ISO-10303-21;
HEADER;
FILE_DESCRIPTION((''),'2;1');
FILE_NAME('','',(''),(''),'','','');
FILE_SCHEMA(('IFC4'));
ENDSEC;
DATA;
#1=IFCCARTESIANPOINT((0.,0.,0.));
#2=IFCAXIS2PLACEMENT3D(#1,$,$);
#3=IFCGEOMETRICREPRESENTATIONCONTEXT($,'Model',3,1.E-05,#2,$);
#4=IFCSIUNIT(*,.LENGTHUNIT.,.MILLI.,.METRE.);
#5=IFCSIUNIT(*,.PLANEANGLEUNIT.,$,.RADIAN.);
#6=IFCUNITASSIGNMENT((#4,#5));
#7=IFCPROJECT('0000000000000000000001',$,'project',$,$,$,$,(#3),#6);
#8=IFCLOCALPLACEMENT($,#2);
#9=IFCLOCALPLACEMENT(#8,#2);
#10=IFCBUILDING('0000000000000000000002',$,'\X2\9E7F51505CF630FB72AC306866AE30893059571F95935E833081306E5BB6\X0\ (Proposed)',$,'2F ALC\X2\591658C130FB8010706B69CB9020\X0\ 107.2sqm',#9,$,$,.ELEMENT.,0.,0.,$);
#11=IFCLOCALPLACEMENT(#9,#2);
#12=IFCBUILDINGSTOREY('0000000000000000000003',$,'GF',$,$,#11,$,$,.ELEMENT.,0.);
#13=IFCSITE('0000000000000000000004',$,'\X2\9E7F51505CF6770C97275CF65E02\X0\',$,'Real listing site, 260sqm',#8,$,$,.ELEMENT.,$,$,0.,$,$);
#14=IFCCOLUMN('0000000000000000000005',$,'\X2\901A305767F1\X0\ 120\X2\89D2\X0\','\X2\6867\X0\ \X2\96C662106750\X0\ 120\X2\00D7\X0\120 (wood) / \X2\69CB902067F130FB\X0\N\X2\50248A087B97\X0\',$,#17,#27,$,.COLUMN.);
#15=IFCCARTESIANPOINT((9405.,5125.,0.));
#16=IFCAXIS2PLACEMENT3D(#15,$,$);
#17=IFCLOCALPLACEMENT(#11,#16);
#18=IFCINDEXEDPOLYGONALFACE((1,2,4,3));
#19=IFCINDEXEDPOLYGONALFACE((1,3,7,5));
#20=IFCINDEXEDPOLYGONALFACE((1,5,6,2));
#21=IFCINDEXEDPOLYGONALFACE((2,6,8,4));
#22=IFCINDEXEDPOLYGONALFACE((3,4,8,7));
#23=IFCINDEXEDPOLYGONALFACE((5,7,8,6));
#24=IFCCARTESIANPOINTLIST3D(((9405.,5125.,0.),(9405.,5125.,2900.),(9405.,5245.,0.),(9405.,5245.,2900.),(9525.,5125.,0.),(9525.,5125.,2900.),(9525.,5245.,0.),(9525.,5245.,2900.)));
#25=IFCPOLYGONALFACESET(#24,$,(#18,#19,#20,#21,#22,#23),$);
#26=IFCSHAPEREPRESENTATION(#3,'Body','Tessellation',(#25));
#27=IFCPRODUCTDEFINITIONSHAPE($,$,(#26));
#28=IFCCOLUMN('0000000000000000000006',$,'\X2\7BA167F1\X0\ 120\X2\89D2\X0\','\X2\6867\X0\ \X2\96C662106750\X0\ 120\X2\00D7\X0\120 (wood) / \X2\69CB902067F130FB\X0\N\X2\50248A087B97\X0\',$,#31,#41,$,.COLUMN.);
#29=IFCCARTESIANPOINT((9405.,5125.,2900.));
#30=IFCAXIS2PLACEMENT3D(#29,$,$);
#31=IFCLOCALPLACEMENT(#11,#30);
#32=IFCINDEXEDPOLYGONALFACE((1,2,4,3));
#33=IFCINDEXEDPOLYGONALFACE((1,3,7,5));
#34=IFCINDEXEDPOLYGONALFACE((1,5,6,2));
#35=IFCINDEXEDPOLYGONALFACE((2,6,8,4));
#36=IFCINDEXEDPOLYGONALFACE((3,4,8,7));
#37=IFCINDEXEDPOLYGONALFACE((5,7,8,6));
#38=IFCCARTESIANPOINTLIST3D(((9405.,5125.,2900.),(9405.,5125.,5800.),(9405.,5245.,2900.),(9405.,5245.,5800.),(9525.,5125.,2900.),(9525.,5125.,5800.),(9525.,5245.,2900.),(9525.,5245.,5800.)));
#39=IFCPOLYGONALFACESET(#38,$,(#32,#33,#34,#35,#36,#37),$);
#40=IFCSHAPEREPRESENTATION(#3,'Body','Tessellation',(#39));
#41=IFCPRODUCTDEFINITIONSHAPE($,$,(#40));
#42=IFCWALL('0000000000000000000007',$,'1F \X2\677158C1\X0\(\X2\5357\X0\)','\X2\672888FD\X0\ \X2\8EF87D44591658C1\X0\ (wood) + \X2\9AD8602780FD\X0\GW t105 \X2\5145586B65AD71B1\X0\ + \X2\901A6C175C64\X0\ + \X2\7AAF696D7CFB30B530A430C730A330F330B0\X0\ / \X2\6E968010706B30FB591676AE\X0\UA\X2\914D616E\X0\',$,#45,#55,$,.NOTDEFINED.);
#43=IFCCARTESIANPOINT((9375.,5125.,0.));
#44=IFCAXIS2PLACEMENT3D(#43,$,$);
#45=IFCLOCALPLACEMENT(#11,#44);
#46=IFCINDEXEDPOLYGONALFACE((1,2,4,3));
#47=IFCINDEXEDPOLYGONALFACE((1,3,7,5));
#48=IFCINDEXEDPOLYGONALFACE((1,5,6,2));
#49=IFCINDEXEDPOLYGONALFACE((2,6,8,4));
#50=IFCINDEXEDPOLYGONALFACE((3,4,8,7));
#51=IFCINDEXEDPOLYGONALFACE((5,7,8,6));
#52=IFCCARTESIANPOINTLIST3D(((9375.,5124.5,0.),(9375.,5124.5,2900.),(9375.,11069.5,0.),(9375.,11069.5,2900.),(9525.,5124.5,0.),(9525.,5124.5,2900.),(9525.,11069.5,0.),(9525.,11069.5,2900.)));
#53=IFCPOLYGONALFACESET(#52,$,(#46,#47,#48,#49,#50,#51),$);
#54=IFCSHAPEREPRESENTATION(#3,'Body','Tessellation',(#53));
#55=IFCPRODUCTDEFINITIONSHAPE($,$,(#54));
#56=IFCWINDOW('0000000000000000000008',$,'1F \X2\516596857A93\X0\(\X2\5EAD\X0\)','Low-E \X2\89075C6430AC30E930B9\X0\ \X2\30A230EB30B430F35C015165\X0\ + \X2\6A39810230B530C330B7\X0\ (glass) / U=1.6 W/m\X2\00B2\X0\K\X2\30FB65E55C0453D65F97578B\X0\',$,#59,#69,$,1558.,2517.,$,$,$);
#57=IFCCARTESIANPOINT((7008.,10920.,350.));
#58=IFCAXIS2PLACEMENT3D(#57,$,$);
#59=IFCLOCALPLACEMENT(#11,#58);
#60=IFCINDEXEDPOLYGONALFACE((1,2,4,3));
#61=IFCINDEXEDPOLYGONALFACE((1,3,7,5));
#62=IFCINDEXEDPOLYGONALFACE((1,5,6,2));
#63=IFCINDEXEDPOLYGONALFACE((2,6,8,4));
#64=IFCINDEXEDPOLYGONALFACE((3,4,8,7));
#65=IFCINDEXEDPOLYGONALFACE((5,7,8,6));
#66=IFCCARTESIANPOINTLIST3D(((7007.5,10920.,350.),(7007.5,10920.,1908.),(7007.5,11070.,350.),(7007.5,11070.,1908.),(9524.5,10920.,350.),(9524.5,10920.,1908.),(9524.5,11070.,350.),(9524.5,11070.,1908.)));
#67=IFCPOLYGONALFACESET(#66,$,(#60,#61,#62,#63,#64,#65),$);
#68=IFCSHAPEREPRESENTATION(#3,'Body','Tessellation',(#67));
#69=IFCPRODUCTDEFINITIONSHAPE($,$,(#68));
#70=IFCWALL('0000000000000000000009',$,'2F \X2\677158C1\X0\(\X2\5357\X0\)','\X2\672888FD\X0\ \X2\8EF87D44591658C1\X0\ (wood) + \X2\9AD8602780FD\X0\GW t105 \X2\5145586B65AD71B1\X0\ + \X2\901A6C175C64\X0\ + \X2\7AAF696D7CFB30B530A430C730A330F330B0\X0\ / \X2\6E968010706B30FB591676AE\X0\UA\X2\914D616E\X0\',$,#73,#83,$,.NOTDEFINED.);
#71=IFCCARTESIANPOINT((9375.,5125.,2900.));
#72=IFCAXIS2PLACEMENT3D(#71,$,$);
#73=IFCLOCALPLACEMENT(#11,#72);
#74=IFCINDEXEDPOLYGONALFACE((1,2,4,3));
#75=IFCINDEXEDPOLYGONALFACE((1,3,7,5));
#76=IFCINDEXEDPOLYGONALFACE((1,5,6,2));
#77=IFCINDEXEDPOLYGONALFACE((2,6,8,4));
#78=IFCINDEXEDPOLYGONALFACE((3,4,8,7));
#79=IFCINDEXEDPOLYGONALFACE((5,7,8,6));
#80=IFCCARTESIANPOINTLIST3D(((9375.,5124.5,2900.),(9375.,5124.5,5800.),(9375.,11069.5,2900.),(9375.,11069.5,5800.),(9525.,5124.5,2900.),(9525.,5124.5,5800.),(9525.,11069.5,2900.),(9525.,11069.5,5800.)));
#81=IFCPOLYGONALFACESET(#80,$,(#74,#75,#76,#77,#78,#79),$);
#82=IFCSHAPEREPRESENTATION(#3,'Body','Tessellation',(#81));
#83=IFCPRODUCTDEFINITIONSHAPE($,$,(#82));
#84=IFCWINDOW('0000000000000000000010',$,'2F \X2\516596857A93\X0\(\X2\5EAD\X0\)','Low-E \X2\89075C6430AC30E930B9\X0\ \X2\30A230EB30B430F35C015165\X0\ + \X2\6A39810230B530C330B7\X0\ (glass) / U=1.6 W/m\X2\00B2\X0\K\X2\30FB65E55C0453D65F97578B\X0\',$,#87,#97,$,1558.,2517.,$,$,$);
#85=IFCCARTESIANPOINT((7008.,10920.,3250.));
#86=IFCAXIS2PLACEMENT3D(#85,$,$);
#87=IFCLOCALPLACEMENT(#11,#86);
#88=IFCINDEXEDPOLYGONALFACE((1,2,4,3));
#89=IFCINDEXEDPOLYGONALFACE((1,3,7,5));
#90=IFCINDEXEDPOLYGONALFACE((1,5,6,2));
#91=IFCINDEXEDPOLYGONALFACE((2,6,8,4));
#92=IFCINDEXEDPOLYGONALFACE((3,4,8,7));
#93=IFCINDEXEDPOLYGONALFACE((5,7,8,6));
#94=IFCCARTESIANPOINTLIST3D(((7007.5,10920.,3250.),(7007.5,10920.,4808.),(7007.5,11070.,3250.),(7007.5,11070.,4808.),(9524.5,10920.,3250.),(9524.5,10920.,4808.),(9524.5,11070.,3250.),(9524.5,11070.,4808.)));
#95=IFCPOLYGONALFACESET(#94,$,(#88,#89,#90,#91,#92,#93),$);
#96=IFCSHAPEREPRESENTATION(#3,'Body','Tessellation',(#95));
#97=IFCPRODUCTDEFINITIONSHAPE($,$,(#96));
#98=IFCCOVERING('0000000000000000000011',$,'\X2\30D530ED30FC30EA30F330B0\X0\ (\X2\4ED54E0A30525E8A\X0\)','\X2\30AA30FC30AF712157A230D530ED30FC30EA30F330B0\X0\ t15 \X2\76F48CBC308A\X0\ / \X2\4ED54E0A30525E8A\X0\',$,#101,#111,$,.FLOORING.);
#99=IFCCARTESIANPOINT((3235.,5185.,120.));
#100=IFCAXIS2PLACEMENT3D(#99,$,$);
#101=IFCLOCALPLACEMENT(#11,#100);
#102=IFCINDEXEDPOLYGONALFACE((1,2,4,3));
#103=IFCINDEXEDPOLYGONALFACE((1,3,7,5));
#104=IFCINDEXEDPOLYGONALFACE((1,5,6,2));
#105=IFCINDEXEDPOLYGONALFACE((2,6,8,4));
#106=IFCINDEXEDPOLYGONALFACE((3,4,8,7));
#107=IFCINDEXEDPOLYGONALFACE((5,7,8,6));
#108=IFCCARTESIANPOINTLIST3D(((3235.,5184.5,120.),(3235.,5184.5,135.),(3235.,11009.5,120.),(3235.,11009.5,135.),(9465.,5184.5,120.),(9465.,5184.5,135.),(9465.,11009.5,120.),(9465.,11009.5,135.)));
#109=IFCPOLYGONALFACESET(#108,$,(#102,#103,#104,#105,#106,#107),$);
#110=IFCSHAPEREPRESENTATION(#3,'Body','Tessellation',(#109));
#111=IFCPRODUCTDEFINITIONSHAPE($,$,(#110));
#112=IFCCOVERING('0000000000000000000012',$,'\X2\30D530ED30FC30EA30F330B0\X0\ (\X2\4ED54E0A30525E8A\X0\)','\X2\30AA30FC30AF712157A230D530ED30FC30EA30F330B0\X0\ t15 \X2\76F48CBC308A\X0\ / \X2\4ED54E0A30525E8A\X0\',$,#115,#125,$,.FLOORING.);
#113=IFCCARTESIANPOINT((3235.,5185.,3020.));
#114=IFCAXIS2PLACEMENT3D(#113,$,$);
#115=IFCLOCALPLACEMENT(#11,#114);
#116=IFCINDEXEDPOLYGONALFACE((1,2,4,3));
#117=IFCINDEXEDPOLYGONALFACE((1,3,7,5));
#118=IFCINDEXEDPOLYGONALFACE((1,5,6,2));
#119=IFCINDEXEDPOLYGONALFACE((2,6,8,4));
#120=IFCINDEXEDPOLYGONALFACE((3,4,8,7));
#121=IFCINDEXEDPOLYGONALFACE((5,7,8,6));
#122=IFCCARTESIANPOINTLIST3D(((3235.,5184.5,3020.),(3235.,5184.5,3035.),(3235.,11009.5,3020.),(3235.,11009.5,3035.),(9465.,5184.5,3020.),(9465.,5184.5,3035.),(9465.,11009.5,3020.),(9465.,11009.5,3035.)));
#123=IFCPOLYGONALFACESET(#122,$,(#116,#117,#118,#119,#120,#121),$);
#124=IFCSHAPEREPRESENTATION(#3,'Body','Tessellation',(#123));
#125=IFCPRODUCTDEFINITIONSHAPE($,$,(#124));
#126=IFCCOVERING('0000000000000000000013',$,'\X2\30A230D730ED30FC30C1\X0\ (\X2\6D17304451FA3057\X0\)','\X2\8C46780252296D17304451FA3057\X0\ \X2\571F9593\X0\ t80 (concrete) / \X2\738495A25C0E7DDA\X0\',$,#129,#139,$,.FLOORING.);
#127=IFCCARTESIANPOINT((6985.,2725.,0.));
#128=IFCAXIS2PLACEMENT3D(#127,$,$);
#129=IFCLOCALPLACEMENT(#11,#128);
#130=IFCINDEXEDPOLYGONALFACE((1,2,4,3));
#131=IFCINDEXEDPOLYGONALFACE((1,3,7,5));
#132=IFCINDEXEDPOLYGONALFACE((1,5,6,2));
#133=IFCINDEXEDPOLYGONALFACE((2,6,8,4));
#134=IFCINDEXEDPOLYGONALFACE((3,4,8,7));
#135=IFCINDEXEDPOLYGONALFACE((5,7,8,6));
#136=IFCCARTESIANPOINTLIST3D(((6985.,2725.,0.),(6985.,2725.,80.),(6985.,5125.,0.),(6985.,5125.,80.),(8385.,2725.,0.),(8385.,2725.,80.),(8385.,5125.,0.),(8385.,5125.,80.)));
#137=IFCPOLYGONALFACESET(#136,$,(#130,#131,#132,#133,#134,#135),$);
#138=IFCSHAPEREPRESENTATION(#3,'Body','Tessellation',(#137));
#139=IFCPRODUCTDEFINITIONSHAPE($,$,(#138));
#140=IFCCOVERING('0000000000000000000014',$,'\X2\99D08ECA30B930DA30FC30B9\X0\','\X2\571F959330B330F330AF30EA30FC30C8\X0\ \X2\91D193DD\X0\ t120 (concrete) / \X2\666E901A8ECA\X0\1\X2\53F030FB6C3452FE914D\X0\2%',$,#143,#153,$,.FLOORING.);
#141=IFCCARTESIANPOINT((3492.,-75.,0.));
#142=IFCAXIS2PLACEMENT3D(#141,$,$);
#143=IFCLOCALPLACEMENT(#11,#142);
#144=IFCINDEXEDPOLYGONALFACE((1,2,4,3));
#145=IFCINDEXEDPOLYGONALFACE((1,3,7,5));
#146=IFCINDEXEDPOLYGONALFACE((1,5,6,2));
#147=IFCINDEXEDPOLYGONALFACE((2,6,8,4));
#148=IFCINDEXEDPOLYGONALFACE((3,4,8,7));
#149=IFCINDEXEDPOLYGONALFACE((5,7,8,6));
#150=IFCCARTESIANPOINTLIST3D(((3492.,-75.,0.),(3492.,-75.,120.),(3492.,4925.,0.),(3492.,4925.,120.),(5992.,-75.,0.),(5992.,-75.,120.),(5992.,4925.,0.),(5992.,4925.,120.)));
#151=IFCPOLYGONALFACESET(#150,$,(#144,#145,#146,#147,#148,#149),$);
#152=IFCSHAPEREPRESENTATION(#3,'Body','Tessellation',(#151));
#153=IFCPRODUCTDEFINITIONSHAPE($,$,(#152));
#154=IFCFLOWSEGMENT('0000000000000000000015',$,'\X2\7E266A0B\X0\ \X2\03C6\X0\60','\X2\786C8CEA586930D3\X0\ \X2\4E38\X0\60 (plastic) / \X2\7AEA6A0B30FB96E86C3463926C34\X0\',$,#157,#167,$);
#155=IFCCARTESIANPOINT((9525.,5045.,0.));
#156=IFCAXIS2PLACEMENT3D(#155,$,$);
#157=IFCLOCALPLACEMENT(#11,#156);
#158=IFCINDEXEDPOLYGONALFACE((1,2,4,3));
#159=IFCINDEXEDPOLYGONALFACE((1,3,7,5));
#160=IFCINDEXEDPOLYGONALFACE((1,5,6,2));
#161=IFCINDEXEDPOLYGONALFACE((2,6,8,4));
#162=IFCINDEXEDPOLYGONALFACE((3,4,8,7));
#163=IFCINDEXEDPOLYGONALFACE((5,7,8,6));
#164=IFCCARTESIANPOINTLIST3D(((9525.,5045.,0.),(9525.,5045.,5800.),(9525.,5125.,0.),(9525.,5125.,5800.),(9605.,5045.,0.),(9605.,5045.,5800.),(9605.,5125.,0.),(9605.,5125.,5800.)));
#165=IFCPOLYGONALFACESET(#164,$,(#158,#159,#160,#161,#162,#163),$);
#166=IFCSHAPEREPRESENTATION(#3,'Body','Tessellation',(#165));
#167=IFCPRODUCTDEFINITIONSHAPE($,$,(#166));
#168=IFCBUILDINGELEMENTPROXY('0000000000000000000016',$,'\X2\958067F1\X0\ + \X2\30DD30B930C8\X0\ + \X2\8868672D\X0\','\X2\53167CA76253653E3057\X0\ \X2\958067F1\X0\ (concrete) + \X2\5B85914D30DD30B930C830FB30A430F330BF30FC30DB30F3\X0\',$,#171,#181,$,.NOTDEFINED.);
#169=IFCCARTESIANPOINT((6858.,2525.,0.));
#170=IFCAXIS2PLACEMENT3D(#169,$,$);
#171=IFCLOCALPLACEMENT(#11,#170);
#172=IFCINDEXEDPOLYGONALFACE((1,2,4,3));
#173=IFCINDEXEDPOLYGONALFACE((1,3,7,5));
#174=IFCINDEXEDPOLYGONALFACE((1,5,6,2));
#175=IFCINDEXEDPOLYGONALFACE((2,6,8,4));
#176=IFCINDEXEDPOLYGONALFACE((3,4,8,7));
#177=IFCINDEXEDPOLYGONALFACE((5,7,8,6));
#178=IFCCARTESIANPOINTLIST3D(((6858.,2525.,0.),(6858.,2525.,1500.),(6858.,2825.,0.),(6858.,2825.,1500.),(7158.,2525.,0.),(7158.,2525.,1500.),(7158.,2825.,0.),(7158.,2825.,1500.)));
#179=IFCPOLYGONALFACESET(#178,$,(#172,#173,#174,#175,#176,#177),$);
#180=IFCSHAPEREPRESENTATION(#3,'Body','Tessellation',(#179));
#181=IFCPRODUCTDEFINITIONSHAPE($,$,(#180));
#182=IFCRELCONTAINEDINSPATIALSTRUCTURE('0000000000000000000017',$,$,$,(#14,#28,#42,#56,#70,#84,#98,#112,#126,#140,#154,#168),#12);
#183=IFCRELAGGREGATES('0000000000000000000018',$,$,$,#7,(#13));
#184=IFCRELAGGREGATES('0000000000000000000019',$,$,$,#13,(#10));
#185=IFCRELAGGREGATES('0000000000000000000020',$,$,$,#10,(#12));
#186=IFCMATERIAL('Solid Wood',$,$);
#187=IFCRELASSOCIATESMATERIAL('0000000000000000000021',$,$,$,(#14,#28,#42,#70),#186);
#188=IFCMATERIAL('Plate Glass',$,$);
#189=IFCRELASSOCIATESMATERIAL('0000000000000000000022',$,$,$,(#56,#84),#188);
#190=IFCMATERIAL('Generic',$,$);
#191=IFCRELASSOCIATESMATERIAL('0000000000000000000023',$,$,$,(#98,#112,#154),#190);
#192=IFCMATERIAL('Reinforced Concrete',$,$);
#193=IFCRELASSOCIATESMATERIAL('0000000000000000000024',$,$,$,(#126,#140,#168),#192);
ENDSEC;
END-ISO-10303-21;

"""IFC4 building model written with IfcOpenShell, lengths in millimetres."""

from ifc_helpers import new_model, si_unit, frame, frame_2d, origin, place, context, project, spatial, rectangle, extrude, material, element, fill, save


model = new_model("IFC4")

# Units and contexts
model_context = context("Model", 3, precision=1e-05, world=origin())
ifc_project = project(units=[si_unit("LENGTHUNIT", "METRE", prefix="MILLI"), si_unit("PLANEANGLEUNIT", "RADIAN")], contexts=[model_context])

# Site, building, storey
site_placement = place(None, origin())
site = spatial("IfcSite", under=ifc_project, at=site_placement, Name="鹿児島県霧島市", ObjectType="Real listing site, 260sqm", CompositionType="ELEMENT", RefElevation=0.0)
building_placement = place(site_placement, origin())
building = spatial("IfcBuilding", under=site, at=building_placement, Name="鹿児島・犬と暮らす土間広めの家 (Proposed)", ObjectType="2F ALC外壁・耐火構造 107.2sqm", CompositionType="ELEMENT", ElevationOfRefHeight=0.0, ElevationOfTerrain=0.0)
storey_placement = place(building_placement, origin())
storey = spatial("IfcBuildingStorey", under=building, at=storey_placement, Name="GF", CompositionType="ELEMENT", Elevation=0.0)

# Columns
ifc_material_1 = material(Name="Solid Wood")
column_1_placement = place(storey_placement, frame((9405.0, 5125.0, 0.0)))
element("IfcColumn", 1, at=column_1_placement, inside=storey, material=ifc_material_1, Name="通し柱 120角", Description="桧 集成材 120×120 (wood) / 構造柱・N値計算", PredefinedType="COLUMN", context=model_context, shape_type="SweptSolid", body=[
    extrude(rectangle(XDim=120.0, YDim=120.0, at=frame_2d((60.0, 60.0))), frame((9405.0, 5125.0, 0.0)), (0.0, 0.0, 1.0), 2900.0),
])
column_2_placement = place(storey_placement, frame((9405.0, 5125.0, 2900.0)))
element("IfcColumn", 2, at=column_2_placement, inside=storey, material=ifc_material_1, Name="管柱 120角", Description="桧 集成材 120×120 (wood) / 構造柱・N値計算", PredefinedType="COLUMN", context=model_context, shape_type="SweptSolid", body=[
    extrude(rectangle(XDim=120.0, YDim=120.0, at=frame_2d((60.0, 60.0))), frame((9405.0, 5125.0, 2900.0)), (0.0, 0.0, 1.0), 2900.0),
])

# Wall, opening, window
wall_1_placement = place(storey_placement, frame((9375.0, 5125.0, 0.0)))
wall_1 = element("IfcWall", 3, at=wall_1_placement, inside=storey, material=ifc_material_1, Name="1F 東壁(南)", Description="木製 軸組外壁 (wood) + 高性能GW t105 充填断熱 + 通気層 + 窯業系サイディング / 準耐火・外皮UA配慮", PredefinedType="NOTDEFINED", context=model_context, shape_type="SweptSolid", body=[
    extrude(rectangle(XDim=150.0, YDim=5945.0, at=frame_2d((75.0, 2972.0))), frame((9375.0, 5125.0, 0.0)), (0.0, 0.0, 1.0), 2900.0),
])
opening_1_placement = place(storey_placement, frame((7008.0, 10920.0, 350.0)))
opening_1 = element("IfcOpeningElement", 4, at=opening_1_placement, cuts=wall_1, PredefinedType="NOTDEFINED", context=model_context, shape_type="SweptSolid", body=[
    extrude(rectangle(XDim=2517.0, YDim=150.0, at=frame_2d((1258.0, 75.0))), frame((7008.0, 10920.0, 350.0)), (0.0, 0.0, 1.0), 1558.0),
])
ifc_material_2 = material(Name="Plate Glass")
window_1_placement = place(storey_placement, frame((7008.0, 10920.0, 350.0)))
window_1 = element("IfcWindow", 5, at=window_1_placement, inside=storey, material=ifc_material_2, Name="1F 入隅窓(庭)", Description="Low-E 複層ガラス アルゴン封入 + 樹脂サッシ (glass) / U=1.6 W/m²K・日射取得型", OverallHeight=1558.0, OverallWidth=2517.0, context=model_context, shape_type="SweptSolid", body=[
    extrude(rectangle(XDim=2517.0, YDim=150.0, at=frame_2d((1258.0, 75.0))), frame((7008.0, 10920.0, 350.0)), (0.0, 0.0, 1.0), 1558.0),
])
fill(opening_1, window_1)

# Wall, opening, window
wall_2_placement = place(storey_placement, frame((9375.0, 5125.0, 2900.0)))
wall_2 = element("IfcWall", 6, at=wall_2_placement, inside=storey, material=ifc_material_1, Name="2F 東壁(南)", Description="木製 軸組外壁 (wood) + 高性能GW t105 充填断熱 + 通気層 + 窯業系サイディング / 準耐火・外皮UA配慮", PredefinedType="NOTDEFINED", context=model_context, shape_type="SweptSolid", body=[
    extrude(rectangle(XDim=150.0, YDim=5945.0, at=frame_2d((75.0, 2972.0))), frame((9375.0, 5125.0, 2900.0)), (0.0, 0.0, 1.0), 2900.0),
])
opening_2_placement = place(storey_placement, frame((7008.0, 10920.0, 3250.0)))
opening_2 = element("IfcOpeningElement", 7, at=opening_2_placement, cuts=wall_2, PredefinedType="NOTDEFINED", context=model_context, shape_type="SweptSolid", body=[
    extrude(rectangle(XDim=2517.0, YDim=150.0, at=frame_2d((1258.0, 75.0))), frame((7008.0, 10920.0, 3250.0)), (0.0, 0.0, 1.0), 1558.0),
])
window_2_placement = place(storey_placement, frame((7008.0, 10920.0, 3250.0)))
window_2 = element("IfcWindow", 8, at=window_2_placement, inside=storey, material=ifc_material_2, Name="2F 入隅窓(庭)", Description="Low-E 複層ガラス アルゴン封入 + 樹脂サッシ (glass) / U=1.6 W/m²K・日射取得型", OverallHeight=1558.0, OverallWidth=2517.0, context=model_context, shape_type="SweptSolid", body=[
    extrude(rectangle(XDim=2517.0, YDim=150.0, at=frame_2d((1258.0, 75.0))), frame((7008.0, 10920.0, 3250.0)), (0.0, 0.0, 1.0), 1558.0),
])
fill(opening_2, window_2)

# Coverings
ifc_material_3 = material(Name="Generic")
covering_1_placement = place(storey_placement, frame((3235.0, 5185.0, 120.0)))
element("IfcCovering", 9, at=covering_1_placement, inside=storey, material=ifc_material_3, Name="フローリング (仕上げ床)", Description="オーク無垢フローリング t15 直貼り / 仕上げ床", PredefinedType="FLOORING", context=model_context, shape_type="SweptSolid", body=[
    extrude(rectangle(XDim=6230.0, YDim=5825.0, at=frame_2d((3115.0, 2912.0))), frame((3235.0, 5185.0, 120.0)), (0.0, 0.0, 1.0), 15.0),
])
covering_2_placement = place(storey_placement, frame((3235.0, 5185.0, 3020.0)))
element("IfcCovering", 10, at=covering_2_placement, inside=storey, material=ifc_material_3, Name="フローリング (仕上げ床)", Description="オーク無垢フローリング t15 直貼り / 仕上げ床", PredefinedType="FLOORING", context=model_context, shape_type="SweptSolid", body=[
    extrude(rectangle(XDim=6230.0, YDim=5825.0, at=frame_2d((3115.0, 2912.0))), frame((3235.0, 5185.0, 3020.0)), (0.0, 0.0, 1.0), 15.0),
])
ifc_material_4 = material(Name="Reinforced Concrete")
covering_3_placement = place(storey_placement, frame((6985.0, 2725.0, 0.0)))
element("IfcCovering", 11, at=covering_3_placement, inside=storey, material=ifc_material_4, Name="アプローチ (洗い出し)", Description="豆砂利洗い出し 土間 t80 (concrete) / 玄関導線", PredefinedType="FLOORING", context=model_context, shape_type="SweptSolid", body=[
    extrude(rectangle(XDim=1400.0, YDim=2400.0, at=frame_2d((700.0, 1200.0))), frame((6985.0, 2725.0, 0.0)), (0.0, 0.0, 1.0), 80.0),
])
covering_4_placement = place(storey_placement, frame((3492.0, -75.0, 0.0)))
element("IfcCovering", 12, at=covering_4_placement, inside=storey, material=ifc_material_4, Name="駐車スペース", Description="土間コンクリート 金鏝 t120 (concrete) / 普通車1台・水勾配2%", PredefinedType="FLOORING", context=model_context, shape_type="SweptSolid", body=[
    extrude(rectangle(XDim=2500.0, YDim=5000.0, at=frame_2d((1250.0, 2500.0))), frame((3492.0, -75.0, 0.0)), (0.0, 0.0, 1.0), 120.0),
])

# Flow segment
flow_segment_placement = place(storey_placement, frame((9525.0, 5045.0, 0.0)))
element("IfcFlowSegment", 13, at=flow_segment_placement, inside=storey, material=ifc_material_3, Name="縦樋 φ60", Description="硬質塩ビ 丸60 (plastic) / 竪樋・雨水排水", context=model_context, shape_type="SweptSolid", body=[
    extrude(rectangle(XDim=80.0, YDim=80.0, at=frame_2d((40.0, 40.0))), frame((9525.0, 5045.0, 0.0)), (0.0, 0.0, 1.0), 5800.0),
])

# Building element proxy
proxy_placement = place(storey_placement, frame((6858.0, 2525.0, 0.0)))
element("IfcBuildingElementProxy", 14, at=proxy_placement, inside=storey, material=ifc_material_4, Name="門柱 + ポスト + 表札", Description="化粧打放し 門柱 (concrete) + 宅配ポスト・インターホン", PredefinedType="NOTDEFINED", context=model_context, shape_type="SweptSolid", body=[
    extrude(rectangle(XDim=300.0, YDim=300.0, at=frame_2d((150.0, 150.0))), frame((6858.0, 2525.0, 0.0)), (0.0, 0.0, 1.0), 1500.0),
])

save(model, "model.ifc")
